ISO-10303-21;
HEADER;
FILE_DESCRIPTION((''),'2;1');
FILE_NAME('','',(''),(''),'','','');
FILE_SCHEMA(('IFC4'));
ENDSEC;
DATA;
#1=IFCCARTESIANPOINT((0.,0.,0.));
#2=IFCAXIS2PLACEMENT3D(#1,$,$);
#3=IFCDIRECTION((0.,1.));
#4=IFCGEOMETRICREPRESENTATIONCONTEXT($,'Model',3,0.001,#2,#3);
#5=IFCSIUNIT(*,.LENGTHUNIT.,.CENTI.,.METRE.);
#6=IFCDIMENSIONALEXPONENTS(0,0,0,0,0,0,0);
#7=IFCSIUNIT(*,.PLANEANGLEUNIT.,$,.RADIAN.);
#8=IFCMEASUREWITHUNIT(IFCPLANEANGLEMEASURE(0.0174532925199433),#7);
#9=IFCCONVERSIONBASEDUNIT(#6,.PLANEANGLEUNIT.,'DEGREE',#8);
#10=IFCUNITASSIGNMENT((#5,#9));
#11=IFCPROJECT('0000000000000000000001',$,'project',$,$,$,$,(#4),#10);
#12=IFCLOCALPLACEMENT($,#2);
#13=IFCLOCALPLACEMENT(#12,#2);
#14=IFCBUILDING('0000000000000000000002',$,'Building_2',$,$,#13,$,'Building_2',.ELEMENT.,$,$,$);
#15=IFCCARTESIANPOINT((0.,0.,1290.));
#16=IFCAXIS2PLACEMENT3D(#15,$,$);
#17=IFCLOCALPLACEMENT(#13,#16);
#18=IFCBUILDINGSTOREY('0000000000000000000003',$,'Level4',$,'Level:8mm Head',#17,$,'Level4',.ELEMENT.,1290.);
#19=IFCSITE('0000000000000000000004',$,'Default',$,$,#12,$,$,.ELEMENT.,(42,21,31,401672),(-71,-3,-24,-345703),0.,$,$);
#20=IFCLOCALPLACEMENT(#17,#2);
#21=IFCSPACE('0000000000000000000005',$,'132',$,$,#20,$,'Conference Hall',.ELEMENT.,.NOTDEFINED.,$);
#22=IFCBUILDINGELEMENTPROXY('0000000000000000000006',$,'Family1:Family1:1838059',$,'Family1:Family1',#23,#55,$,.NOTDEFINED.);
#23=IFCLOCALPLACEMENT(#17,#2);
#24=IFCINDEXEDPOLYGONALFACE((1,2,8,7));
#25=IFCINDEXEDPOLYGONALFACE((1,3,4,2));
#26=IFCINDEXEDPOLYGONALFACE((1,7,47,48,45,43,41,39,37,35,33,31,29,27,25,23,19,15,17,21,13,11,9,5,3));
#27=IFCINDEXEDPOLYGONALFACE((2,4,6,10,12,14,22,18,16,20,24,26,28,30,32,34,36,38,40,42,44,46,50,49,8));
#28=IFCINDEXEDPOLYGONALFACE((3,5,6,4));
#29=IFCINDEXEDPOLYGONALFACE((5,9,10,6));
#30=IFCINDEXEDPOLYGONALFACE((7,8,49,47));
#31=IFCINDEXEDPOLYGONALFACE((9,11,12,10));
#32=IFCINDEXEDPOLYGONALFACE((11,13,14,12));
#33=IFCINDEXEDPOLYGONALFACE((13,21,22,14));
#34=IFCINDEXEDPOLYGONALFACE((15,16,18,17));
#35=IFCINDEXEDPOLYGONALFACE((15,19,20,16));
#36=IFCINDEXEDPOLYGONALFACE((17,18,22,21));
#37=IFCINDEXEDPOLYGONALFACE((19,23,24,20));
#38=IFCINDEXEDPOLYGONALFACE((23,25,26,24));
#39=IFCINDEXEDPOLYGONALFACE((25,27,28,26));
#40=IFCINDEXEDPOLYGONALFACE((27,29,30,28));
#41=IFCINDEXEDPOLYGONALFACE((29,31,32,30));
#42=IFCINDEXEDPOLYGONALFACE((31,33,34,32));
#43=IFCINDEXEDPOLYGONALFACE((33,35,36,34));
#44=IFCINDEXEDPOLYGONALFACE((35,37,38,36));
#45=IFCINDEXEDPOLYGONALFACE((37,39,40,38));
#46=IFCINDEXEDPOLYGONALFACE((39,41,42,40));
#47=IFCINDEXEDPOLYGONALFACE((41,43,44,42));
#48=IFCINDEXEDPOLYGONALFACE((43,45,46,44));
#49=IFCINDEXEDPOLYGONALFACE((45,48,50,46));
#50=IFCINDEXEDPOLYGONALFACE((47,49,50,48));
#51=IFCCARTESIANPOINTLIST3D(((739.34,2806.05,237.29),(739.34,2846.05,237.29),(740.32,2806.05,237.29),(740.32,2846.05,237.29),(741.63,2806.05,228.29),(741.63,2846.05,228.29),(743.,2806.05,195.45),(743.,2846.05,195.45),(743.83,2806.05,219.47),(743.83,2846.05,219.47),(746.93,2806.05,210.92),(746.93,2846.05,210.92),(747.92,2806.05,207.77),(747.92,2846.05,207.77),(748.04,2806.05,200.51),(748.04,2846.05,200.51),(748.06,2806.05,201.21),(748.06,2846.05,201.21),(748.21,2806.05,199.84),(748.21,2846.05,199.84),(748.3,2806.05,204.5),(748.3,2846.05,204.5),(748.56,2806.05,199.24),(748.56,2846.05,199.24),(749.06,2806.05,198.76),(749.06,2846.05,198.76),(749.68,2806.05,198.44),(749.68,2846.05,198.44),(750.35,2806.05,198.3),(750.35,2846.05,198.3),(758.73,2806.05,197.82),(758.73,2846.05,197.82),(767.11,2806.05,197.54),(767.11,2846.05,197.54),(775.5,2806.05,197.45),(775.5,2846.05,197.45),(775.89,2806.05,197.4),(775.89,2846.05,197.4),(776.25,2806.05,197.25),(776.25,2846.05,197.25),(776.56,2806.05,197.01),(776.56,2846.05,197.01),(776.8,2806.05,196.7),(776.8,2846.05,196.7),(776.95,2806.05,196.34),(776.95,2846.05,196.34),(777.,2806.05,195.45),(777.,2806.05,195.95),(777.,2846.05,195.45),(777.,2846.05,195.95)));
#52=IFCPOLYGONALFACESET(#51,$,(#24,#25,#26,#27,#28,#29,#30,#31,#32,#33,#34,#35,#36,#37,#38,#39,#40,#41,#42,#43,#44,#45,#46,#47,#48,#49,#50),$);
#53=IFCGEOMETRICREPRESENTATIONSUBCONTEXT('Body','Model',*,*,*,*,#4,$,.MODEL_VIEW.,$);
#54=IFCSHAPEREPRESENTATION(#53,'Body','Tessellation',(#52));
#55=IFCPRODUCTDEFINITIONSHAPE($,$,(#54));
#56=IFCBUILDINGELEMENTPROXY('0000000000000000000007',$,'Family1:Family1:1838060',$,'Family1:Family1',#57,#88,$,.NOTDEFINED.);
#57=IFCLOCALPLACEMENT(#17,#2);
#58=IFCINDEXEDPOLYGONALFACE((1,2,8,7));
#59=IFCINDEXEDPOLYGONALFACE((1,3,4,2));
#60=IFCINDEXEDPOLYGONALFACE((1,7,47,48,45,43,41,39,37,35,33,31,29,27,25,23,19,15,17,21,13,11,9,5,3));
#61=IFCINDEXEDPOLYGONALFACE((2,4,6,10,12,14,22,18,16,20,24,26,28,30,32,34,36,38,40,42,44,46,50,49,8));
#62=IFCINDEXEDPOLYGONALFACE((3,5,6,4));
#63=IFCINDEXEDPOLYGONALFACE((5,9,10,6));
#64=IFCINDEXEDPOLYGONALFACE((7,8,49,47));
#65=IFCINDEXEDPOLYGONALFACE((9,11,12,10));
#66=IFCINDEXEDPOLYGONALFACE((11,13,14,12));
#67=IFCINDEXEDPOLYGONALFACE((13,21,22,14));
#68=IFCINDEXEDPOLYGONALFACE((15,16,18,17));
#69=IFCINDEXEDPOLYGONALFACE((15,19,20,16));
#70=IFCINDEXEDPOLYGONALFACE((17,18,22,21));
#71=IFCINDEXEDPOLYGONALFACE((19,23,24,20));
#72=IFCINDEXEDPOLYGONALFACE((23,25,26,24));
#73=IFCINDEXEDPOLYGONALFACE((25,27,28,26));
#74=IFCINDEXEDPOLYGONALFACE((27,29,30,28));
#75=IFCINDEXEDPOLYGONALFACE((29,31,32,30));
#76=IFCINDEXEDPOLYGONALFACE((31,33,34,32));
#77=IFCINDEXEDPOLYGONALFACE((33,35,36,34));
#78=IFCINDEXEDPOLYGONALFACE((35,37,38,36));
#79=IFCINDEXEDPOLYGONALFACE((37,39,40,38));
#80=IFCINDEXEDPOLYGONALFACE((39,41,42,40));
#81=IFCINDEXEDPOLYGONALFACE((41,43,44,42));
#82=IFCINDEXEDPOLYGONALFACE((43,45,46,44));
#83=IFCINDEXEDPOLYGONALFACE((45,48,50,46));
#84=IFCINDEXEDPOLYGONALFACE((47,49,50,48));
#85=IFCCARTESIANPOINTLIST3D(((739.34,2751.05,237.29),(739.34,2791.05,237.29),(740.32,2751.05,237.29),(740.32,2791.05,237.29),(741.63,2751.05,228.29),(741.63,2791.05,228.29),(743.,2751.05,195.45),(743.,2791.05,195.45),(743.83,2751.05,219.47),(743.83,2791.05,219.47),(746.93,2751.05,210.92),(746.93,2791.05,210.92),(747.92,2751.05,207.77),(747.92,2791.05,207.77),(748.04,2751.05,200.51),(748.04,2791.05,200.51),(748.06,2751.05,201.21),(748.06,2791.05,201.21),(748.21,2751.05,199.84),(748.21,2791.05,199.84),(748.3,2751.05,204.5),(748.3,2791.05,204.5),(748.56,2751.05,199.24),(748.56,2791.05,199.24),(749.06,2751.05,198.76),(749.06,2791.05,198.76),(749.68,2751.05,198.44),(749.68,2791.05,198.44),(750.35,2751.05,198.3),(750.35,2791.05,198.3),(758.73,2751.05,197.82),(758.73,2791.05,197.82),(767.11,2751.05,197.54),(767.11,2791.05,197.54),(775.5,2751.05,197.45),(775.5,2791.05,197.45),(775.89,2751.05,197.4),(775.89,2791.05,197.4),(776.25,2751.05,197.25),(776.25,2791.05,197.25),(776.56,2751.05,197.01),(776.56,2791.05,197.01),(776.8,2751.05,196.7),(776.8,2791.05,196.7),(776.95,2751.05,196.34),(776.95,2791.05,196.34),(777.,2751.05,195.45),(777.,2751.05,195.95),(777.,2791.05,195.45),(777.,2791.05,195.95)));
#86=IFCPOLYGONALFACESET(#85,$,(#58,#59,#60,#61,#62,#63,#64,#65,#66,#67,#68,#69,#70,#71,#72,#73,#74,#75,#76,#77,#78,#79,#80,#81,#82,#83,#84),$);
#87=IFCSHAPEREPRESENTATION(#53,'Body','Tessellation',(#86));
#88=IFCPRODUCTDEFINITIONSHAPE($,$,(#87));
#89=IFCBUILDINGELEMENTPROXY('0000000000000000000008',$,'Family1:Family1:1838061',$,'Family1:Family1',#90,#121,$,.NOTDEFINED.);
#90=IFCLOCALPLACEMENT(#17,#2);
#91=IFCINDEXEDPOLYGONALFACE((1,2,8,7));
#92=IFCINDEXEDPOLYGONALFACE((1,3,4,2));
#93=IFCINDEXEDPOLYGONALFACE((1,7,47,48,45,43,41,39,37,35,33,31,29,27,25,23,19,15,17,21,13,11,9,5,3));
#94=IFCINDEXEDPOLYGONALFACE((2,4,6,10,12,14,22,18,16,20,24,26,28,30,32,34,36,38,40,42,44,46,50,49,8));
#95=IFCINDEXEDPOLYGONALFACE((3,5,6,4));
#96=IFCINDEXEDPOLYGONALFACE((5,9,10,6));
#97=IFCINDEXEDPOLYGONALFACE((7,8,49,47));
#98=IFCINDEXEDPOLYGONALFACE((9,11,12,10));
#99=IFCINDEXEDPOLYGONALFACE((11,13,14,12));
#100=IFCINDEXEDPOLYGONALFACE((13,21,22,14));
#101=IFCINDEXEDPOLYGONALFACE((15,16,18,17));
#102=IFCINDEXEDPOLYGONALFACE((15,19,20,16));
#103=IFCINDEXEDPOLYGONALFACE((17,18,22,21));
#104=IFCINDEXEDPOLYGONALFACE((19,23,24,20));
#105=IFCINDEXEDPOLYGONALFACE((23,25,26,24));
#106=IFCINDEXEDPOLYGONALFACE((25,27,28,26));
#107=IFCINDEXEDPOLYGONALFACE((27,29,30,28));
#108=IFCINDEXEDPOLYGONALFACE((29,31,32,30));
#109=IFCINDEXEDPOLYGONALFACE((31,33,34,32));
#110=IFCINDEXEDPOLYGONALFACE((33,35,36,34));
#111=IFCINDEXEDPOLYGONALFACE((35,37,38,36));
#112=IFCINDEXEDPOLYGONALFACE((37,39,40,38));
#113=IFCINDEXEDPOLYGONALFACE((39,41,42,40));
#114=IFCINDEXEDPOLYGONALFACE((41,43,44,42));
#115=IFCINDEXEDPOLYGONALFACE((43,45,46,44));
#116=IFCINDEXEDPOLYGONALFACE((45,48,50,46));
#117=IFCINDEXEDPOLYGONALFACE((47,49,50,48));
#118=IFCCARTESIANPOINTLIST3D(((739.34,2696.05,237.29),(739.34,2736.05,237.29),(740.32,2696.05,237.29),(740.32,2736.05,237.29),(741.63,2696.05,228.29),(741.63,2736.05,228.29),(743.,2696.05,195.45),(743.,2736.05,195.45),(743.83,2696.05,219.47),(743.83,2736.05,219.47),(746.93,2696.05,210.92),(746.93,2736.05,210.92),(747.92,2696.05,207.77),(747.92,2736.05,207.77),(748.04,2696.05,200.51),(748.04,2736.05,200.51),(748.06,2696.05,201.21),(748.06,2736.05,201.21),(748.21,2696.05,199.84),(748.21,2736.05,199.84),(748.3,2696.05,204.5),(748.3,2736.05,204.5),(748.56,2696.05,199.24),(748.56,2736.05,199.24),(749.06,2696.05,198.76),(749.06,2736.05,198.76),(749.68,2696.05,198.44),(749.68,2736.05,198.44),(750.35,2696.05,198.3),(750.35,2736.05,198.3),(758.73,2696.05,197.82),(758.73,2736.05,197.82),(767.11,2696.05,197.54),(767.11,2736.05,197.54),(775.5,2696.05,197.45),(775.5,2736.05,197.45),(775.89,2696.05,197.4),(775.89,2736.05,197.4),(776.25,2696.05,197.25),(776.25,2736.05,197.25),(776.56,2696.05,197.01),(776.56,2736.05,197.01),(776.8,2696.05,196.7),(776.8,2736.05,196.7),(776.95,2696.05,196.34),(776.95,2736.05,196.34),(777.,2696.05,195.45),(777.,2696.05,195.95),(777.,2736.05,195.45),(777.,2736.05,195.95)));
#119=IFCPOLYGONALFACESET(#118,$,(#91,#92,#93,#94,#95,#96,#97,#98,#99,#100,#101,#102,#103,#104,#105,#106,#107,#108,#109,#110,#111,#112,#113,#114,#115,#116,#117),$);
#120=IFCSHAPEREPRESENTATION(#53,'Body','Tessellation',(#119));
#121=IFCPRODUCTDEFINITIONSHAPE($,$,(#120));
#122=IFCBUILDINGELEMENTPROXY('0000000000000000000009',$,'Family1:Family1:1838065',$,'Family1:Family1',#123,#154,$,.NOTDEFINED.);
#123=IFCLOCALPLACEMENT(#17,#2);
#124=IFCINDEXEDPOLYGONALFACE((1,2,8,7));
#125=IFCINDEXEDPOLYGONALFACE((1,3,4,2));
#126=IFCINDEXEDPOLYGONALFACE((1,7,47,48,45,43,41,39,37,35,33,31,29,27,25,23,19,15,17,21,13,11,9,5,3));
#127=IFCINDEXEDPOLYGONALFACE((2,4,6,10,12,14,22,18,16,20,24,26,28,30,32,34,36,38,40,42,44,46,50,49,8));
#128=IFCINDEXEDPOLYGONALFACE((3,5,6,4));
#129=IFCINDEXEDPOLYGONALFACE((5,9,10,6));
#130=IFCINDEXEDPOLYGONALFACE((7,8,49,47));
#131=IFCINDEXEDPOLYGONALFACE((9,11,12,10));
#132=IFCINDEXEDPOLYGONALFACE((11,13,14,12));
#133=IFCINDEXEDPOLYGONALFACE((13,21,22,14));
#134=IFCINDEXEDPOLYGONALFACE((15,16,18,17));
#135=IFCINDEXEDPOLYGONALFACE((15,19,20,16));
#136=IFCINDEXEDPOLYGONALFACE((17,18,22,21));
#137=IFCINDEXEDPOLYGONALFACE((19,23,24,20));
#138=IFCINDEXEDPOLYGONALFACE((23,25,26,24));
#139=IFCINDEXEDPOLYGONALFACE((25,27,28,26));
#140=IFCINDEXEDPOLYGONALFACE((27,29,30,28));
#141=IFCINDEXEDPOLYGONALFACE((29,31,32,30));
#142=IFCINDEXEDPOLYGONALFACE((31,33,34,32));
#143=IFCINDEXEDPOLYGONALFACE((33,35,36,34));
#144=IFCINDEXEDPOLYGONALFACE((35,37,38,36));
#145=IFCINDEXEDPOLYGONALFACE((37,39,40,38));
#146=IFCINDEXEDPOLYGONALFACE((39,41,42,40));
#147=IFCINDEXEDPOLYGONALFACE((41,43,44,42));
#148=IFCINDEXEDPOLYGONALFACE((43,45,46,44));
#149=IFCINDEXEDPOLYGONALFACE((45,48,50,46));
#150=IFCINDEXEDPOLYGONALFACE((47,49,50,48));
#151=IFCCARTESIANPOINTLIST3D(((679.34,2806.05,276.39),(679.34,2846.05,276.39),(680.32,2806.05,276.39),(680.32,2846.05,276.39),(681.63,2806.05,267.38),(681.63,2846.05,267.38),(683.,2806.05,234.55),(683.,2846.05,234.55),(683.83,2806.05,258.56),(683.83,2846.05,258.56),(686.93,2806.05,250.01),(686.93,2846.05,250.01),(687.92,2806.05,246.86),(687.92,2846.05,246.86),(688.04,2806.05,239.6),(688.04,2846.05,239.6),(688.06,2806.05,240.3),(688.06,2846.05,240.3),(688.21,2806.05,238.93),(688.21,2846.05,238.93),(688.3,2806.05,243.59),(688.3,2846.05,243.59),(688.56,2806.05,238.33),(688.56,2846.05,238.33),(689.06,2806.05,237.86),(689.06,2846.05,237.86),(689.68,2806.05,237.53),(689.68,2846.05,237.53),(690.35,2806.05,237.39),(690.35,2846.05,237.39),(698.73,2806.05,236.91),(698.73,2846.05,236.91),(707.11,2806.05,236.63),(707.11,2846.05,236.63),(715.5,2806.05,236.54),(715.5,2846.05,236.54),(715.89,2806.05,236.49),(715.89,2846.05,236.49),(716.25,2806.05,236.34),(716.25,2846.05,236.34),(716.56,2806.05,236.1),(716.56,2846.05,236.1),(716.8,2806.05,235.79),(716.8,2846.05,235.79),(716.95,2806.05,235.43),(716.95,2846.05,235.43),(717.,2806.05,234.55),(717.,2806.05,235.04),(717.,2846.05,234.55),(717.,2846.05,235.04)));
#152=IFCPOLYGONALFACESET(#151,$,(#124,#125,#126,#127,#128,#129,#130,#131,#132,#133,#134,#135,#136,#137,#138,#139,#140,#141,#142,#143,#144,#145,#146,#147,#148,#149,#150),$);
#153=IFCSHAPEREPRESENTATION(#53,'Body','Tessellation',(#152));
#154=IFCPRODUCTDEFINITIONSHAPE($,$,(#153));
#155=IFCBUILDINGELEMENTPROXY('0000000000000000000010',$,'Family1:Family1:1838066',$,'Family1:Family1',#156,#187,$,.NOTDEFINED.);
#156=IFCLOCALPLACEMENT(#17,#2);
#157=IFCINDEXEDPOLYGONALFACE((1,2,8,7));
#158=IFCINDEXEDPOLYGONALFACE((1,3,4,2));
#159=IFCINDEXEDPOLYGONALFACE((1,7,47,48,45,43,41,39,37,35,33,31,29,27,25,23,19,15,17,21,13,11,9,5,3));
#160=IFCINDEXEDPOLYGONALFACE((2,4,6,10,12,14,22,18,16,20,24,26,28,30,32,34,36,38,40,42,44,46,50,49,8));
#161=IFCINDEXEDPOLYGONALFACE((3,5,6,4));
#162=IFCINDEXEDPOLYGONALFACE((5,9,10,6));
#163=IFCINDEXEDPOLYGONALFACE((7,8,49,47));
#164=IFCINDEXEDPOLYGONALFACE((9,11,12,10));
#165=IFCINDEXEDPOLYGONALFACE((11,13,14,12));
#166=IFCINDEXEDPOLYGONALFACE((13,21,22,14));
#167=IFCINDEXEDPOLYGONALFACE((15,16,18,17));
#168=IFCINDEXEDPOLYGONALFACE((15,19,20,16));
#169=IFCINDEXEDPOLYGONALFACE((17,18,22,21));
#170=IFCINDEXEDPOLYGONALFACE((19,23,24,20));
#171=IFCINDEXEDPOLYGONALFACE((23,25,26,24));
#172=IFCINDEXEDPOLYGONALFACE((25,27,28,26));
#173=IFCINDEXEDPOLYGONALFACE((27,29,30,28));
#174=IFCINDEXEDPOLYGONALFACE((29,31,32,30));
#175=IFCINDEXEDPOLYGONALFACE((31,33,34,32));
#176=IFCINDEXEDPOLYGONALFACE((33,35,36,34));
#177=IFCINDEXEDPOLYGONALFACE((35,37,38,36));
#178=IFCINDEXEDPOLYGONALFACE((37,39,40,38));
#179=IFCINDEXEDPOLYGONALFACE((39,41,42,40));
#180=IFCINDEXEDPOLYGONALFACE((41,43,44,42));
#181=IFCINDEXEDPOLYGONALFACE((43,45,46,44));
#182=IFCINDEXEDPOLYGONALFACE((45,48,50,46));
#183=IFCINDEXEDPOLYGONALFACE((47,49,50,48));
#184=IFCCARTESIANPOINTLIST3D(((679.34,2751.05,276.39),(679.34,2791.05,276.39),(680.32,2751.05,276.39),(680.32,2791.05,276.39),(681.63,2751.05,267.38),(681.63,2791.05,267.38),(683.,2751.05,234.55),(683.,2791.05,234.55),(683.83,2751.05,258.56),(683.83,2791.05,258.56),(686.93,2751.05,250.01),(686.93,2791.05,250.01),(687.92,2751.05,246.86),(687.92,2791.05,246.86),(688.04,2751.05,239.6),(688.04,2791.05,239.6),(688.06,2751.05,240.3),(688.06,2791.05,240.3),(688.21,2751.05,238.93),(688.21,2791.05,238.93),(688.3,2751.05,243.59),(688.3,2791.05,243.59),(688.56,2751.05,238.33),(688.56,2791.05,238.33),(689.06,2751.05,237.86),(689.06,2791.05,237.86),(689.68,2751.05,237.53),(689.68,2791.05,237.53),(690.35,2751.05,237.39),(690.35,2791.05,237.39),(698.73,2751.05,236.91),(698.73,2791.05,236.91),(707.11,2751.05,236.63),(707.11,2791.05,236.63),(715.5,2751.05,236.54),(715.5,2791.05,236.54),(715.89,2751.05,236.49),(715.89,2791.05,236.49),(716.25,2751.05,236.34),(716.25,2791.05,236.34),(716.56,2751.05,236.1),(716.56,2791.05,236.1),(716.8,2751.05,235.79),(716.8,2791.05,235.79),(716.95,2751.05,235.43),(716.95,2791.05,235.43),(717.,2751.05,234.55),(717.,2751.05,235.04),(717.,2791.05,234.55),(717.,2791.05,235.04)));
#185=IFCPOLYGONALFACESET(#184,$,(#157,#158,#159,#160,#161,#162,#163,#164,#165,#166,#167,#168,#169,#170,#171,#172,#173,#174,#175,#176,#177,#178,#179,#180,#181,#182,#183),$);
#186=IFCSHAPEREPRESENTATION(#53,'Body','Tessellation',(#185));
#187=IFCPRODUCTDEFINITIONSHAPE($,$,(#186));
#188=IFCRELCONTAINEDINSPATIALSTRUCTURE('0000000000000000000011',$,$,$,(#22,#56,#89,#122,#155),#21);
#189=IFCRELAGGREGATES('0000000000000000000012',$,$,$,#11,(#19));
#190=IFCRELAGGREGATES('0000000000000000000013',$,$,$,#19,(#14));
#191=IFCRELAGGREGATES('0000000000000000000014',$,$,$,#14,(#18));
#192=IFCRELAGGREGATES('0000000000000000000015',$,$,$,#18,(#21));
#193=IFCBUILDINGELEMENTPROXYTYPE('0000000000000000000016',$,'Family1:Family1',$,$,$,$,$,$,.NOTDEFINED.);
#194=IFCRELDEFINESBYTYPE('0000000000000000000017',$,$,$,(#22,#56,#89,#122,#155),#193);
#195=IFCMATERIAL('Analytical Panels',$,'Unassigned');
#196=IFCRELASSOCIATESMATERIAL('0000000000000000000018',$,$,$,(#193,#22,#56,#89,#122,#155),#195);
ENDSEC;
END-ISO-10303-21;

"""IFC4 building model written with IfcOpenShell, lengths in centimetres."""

from ifc_helpers import new_model, entity, si_unit, converted_unit, direction, frame, origin, place, context, subcontext, project, spatial, line, arc, indexed_curve, outline, extrude, source, transform, mapped, material, type_object, type_shapes, element, save


model = new_model("IFC4")

# Units and contexts
model_context = context("Model", 3, precision=0.001, world=origin(), true_north=direction((0.0, 1.0)))
body_context = subcontext(model_context, "Body", "Model", "MODEL_VIEW")
ifc_project = project(units=[si_unit("LENGTHUNIT", "METRE", prefix="CENTI"), converted_unit("PLANEANGLEUNIT", "DEGREE", entity("IfcPlaneAngleMeasure", 0.0174532925199433), si_unit("PLANEANGLEUNIT", "RADIAN"), dimensions=[0, 0, 0, 0, 0, 0, 0])], contexts=[model_context])

# Site, building, storey, space
site_placement = place(None, origin())
site = spatial("IfcSite", under=ifc_project, at=site_placement, Name="Default", CompositionType="ELEMENT", RefLatitude=(42, 21, 31, 401672), RefLongitude=(-71, -3, -24, -345703), RefElevation=0.0)
building_placement = place(site_placement, origin())
building = spatial("IfcBuilding", under=site, at=building_placement, Name="Building_2", LongName="Building_2", CompositionType="ELEMENT")
storey_placement = place(building_placement, frame((0.0, 0.0, 1290.0)))
storey = spatial("IfcBuildingStorey", under=building, at=storey_placement, Name="Level4", ObjectType="Level:8mm Head", LongName="Level4", CompositionType="ELEMENT", Elevation=1290.0)
space_placement = place(storey_placement, origin())
space = spatial("IfcSpace", under=storey, at=space_placement, Name="132", LongName="Conference Hall", CompositionType="ELEMENT", PredefinedType="NOTDEFINED")

# Building element proxies
ifc_material_1 = material(Name="Analytical Panels", Category="Unassigned")
building_element_proxy_type_1 = type_object("IfcBuildingElementProxyType", Name="Family1:Family1", PredefinedType="NOTDEFINED", material=ifc_material_1)
shared_shape_1 = source(origin(), body_context, "Body", "SweptSolid", [
    extrude(outline(indexed_curve([(-11.13, -13.3), (30.87, -13.3), (30.78, -12.32), (17.19, -11.21), (3.93, -8.04), (-0.94, -7.2), (-5.84, -7.76), (-7.84, -7.43), (-8.94, -5.73), (-10.68, 6.74), (-11.98, 19.25), (-12.51, 20.27), (-13.6, 20.61), (-14.09, 20.57)], segments=[line(1, 2, 3), arc(3, 4, 5), arc(5, 6, 7), arc(7, 8, 9), arc(9, 10, 11), arc(11, 12, 13), line(13, 14, 1)], self_intersect=False)), frame((-20.0, 6.72, 12.25), z_axis=(1.0, 0.0, 0.0), x_axis=(0.0, 0.087156, 0.996195)), (0.0, 0.0, 1.0), 40.0),
])
type_shapes(building_element_proxy_type_1, [shared_shape_1])
for number, where, z_axis, x_axis, name in (
    (1, (762.0, 2826.05, 195.45), (0.0, 0.0, 1.0), (0.0, 1.0, 0.0), "Family1:Family1:1838059"),
    (2, (762.0, 2771.05, 195.45), (0.0, 0.0, 1.0), (0.0, 1.0, 0.0), "Family1:Family1:1838060"),
    (3, (762.0, 2716.05, 195.45), (0.0, 0.0, 1.0), (0.0, 1.0, 0.0), "Family1:Family1:1838061"),
    (4, (702.0, 2826.05, 234.55), (0.0, 0.0, 1.0), (0.0, 1.0, 0.0), "Family1:Family1:1838065"),
    (5, (702.0, 2771.05, 234.55), (0.0, 0.0, 1.0), (0.0, 1.0, 0.0), "Family1:Family1:1838066"),
):
    element("IfcBuildingElementProxy", number, at=place(space_placement, frame(where, z_axis=z_axis, x_axis=x_axis)), inside=space, type_object=building_element_proxy_type_1, material=ifc_material_1, Name=name, ObjectType="Family1:Family1", PredefinedType="NOTDEFINED", context=body_context, shape_type="MappedRepresentation", body=[
        mapped(shared_shape_1, transform((0.0, 0.0, 0.0), scale=1.0)),
    ])

save(model, "model.ifc")
